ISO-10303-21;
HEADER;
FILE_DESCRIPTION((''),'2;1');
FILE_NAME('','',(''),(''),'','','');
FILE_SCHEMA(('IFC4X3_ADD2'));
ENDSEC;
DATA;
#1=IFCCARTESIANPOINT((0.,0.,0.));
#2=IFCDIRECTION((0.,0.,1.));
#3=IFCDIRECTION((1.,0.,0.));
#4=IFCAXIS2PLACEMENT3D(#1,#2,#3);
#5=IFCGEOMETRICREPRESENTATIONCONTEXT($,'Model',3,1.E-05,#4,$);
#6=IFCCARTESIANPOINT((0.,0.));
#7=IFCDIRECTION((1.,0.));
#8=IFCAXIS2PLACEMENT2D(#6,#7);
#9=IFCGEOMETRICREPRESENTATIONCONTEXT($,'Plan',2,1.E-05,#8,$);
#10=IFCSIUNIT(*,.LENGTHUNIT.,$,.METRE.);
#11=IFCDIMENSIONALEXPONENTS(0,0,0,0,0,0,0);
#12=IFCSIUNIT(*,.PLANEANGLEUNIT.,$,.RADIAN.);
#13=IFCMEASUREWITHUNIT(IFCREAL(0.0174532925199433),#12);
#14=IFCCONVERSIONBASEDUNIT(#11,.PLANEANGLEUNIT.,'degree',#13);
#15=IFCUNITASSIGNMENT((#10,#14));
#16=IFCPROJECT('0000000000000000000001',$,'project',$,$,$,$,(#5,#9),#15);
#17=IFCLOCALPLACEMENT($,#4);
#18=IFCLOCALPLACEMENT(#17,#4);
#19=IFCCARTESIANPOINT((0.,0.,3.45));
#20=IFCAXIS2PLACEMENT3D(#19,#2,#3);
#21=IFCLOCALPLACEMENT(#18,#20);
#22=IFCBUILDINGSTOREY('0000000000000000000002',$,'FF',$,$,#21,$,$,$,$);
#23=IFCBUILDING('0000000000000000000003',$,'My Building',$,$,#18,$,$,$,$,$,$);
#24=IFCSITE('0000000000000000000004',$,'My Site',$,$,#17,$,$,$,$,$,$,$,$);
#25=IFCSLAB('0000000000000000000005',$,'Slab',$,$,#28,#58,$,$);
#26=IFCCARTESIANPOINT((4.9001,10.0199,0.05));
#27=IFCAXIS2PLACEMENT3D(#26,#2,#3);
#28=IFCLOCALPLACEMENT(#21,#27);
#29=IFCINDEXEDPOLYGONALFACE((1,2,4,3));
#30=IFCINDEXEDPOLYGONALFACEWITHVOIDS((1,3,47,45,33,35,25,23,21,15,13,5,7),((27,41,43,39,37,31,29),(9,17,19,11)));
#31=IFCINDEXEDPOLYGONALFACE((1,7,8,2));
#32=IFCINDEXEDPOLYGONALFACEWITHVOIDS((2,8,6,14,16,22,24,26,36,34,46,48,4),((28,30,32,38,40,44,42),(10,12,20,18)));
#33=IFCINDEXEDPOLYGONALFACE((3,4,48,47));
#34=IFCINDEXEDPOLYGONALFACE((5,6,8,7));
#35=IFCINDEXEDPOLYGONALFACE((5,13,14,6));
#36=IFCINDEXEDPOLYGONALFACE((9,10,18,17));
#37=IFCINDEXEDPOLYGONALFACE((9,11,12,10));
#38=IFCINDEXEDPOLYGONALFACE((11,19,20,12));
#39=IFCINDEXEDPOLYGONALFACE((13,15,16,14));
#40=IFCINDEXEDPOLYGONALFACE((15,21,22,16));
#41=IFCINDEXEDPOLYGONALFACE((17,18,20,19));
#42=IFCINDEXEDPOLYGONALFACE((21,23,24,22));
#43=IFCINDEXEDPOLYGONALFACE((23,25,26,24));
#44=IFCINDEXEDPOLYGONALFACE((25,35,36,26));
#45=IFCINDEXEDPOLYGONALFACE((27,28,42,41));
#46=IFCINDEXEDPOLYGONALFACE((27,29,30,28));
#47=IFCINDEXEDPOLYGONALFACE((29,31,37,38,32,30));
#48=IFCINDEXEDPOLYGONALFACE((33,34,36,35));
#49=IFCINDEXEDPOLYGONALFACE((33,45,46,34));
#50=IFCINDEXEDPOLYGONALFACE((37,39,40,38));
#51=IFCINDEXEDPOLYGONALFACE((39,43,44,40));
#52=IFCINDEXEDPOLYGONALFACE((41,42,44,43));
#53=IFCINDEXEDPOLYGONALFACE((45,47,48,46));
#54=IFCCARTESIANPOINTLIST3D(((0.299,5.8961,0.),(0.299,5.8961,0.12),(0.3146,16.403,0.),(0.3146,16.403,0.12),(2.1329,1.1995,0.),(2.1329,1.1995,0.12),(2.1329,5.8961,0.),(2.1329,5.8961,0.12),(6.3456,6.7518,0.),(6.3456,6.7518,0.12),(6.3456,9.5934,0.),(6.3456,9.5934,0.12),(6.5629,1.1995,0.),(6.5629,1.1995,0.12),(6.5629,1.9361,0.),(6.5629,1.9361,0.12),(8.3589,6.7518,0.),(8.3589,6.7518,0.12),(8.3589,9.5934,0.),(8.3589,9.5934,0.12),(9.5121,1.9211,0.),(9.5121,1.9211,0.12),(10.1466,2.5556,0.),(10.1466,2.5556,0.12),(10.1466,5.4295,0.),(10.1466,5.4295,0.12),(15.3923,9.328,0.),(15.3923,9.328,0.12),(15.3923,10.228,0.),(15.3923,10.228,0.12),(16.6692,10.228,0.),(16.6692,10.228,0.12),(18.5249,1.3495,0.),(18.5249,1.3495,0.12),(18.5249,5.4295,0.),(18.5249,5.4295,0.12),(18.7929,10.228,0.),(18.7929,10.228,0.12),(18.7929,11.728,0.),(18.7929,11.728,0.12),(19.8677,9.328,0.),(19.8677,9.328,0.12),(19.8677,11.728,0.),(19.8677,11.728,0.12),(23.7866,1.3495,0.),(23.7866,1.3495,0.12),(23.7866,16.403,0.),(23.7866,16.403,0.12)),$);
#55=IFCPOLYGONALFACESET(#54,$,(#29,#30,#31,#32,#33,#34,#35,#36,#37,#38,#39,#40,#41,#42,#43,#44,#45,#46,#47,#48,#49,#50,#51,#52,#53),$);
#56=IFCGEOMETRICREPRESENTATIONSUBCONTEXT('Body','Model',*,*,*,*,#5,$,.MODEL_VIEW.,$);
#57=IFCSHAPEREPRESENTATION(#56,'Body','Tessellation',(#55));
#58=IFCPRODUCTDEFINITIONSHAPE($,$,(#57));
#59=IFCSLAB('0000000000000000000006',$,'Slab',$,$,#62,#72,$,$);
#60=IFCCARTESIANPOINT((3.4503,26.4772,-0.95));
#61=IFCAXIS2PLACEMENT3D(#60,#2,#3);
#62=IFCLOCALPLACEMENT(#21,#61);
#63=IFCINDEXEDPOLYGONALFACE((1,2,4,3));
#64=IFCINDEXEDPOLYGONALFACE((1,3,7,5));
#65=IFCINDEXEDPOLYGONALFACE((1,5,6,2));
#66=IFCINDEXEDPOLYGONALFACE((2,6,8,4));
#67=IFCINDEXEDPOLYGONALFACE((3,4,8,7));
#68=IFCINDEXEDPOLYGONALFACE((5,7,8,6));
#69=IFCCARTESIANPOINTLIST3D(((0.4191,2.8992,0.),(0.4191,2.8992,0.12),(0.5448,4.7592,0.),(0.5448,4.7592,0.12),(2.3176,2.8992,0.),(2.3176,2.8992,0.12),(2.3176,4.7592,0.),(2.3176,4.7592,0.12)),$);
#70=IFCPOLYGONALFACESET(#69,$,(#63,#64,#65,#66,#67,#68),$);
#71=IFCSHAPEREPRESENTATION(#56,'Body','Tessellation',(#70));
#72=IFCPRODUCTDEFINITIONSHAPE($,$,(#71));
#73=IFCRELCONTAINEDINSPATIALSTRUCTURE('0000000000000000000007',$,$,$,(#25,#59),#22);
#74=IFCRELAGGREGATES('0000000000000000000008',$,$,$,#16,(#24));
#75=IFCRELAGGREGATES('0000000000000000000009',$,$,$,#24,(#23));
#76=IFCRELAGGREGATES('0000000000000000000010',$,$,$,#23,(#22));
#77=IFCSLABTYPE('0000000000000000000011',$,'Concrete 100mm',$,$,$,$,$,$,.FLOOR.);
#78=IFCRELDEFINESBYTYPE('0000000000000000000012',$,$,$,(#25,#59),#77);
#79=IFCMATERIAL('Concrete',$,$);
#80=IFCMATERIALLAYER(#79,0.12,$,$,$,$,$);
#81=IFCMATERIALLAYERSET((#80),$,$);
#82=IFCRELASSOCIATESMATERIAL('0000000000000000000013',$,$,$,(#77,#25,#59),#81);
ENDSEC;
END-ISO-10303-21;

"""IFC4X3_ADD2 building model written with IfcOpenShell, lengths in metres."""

from ifc_helpers import new_model, entity, si_unit, converted_unit, frame, origin_with_axes, origin_2d_with_axis, place, context, subcontext, project, spatial, line, indexed_curve, outline, extrude, material, layer, layer_set, layer_usage, type_object, element, save


model = new_model("IFC4X3_ADD2")

# Units and contexts
model_context = context("Model", 3, precision=1e-05, world=origin_with_axes())
plan_context = context("Plan", 2, precision=1e-05, world=origin_2d_with_axis())
body_context_1 = subcontext(model_context, "Body", "Model", "MODEL_VIEW")
ifc_project = project(units=[si_unit("LENGTHUNIT", "METRE"), converted_unit("PLANEANGLEUNIT", "degree", entity("IfcReal", 0.0174532925199433), si_unit("PLANEANGLEUNIT", "RADIAN"), dimensions=[0, 0, 0, 0, 0, 0, 0])], contexts=[model_context, plan_context])

# Site, building, storey
site_placement = place(None, origin_with_axes())
site = spatial("IfcSite", under=ifc_project, at=site_placement, Name="My Site")
building_placement = place(site_placement, origin_with_axes())
building = spatial("IfcBuilding", under=site, at=building_placement, Name="My Building")
storey_placement = place(building_placement, frame((0.0, 0.0, 3.45), z_axis=(0.0, 0.0, 1.0), x_axis=(1.0, 0.0, 0.0)))
storey = spatial("IfcBuildingStorey", under=building, at=storey_placement, Name="FF")

# Slabs
ifc_material_1 = material(Name="Concrete")
ifc_layer_1 = layer(ifc_material_1, 0.12)
ifc_layer_set_1 = layer_set([ifc_layer_1])
ifc_layer_usage_1 = layer_usage(ifc_layer_set_1, "AXIS3", "POSITIVE", 0.0)
slab_type = type_object("IfcSlabType", Name="Concrete 100mm", PredefinedType="FLOOR", material=ifc_layer_set_1)
slab_1_placement = place(storey_placement, frame((4.9001, 10.0199, 0.05), z_axis=(0.0, 0.0, 1.0), x_axis=(1.0, 0.0, 0.0)))
element("IfcSlab", 1, at=slab_1_placement, inside=storey, type_object=slab_type, material=ifc_layer_usage_1, Name="Slab", context=body_context_1, shape_type="SweptSolid", body=[
    extrude(outline(indexed_curve([(2.1329, 5.8961), (2.1329, 1.1995), (6.5629, 1.1995), (6.5629, 1.9361), (9.5121, 1.9211), (10.1466, 2.5556), (10.1466, 5.4295), (18.5249, 5.4295), (18.5249, 1.3495), (23.7866, 1.3495), (23.7866, 16.403), (0.3146, 16.403), (0.299, 5.8961), (2.1329, 5.8961)]), holes=[indexed_curve([(15.3923, 9.328), (15.3923, 10.228), (16.6692, 10.228), (18.7929, 10.228), (18.7929, 11.728), (19.8677, 11.728), (19.8677, 9.328), (15.3923, 9.328)]), indexed_curve([(6.3456, 9.5934), (8.3589, 9.5934), (8.3589, 6.7518), (6.3456, 6.7518), (6.3456, 9.5934)])]), None, (0.0, 0.0, 1.0), 0.12),
])
ifc_layer_usage_2 = layer_usage(ifc_layer_set_1, "AXIS3", "POSITIVE", 0.0)
slab_2_placement = place(storey_placement, frame((3.4503, 26.4772, -0.95), z_axis=(0.0, 0.0, 1.0), x_axis=(1.0, 0.0, 0.0)))
element("IfcSlab", 2, at=slab_2_placement, inside=storey, type_object=slab_type, material=ifc_layer_usage_2, Name="Slab", context=body_context_1, shape_type="SweptSolid", body=[
    extrude(outline(indexed_curve([(0.5448, 4.7592), (2.3176, 4.7592), (2.3176, 2.8992), (0.4191, 2.8992)], segments=[line(4, 1), line(1, 2), line(2, 3), line(3, 4)], self_intersect=False)), None, (0.0, 0.0, 1.0), 0.12),
])

save(model, "model.ifc")
